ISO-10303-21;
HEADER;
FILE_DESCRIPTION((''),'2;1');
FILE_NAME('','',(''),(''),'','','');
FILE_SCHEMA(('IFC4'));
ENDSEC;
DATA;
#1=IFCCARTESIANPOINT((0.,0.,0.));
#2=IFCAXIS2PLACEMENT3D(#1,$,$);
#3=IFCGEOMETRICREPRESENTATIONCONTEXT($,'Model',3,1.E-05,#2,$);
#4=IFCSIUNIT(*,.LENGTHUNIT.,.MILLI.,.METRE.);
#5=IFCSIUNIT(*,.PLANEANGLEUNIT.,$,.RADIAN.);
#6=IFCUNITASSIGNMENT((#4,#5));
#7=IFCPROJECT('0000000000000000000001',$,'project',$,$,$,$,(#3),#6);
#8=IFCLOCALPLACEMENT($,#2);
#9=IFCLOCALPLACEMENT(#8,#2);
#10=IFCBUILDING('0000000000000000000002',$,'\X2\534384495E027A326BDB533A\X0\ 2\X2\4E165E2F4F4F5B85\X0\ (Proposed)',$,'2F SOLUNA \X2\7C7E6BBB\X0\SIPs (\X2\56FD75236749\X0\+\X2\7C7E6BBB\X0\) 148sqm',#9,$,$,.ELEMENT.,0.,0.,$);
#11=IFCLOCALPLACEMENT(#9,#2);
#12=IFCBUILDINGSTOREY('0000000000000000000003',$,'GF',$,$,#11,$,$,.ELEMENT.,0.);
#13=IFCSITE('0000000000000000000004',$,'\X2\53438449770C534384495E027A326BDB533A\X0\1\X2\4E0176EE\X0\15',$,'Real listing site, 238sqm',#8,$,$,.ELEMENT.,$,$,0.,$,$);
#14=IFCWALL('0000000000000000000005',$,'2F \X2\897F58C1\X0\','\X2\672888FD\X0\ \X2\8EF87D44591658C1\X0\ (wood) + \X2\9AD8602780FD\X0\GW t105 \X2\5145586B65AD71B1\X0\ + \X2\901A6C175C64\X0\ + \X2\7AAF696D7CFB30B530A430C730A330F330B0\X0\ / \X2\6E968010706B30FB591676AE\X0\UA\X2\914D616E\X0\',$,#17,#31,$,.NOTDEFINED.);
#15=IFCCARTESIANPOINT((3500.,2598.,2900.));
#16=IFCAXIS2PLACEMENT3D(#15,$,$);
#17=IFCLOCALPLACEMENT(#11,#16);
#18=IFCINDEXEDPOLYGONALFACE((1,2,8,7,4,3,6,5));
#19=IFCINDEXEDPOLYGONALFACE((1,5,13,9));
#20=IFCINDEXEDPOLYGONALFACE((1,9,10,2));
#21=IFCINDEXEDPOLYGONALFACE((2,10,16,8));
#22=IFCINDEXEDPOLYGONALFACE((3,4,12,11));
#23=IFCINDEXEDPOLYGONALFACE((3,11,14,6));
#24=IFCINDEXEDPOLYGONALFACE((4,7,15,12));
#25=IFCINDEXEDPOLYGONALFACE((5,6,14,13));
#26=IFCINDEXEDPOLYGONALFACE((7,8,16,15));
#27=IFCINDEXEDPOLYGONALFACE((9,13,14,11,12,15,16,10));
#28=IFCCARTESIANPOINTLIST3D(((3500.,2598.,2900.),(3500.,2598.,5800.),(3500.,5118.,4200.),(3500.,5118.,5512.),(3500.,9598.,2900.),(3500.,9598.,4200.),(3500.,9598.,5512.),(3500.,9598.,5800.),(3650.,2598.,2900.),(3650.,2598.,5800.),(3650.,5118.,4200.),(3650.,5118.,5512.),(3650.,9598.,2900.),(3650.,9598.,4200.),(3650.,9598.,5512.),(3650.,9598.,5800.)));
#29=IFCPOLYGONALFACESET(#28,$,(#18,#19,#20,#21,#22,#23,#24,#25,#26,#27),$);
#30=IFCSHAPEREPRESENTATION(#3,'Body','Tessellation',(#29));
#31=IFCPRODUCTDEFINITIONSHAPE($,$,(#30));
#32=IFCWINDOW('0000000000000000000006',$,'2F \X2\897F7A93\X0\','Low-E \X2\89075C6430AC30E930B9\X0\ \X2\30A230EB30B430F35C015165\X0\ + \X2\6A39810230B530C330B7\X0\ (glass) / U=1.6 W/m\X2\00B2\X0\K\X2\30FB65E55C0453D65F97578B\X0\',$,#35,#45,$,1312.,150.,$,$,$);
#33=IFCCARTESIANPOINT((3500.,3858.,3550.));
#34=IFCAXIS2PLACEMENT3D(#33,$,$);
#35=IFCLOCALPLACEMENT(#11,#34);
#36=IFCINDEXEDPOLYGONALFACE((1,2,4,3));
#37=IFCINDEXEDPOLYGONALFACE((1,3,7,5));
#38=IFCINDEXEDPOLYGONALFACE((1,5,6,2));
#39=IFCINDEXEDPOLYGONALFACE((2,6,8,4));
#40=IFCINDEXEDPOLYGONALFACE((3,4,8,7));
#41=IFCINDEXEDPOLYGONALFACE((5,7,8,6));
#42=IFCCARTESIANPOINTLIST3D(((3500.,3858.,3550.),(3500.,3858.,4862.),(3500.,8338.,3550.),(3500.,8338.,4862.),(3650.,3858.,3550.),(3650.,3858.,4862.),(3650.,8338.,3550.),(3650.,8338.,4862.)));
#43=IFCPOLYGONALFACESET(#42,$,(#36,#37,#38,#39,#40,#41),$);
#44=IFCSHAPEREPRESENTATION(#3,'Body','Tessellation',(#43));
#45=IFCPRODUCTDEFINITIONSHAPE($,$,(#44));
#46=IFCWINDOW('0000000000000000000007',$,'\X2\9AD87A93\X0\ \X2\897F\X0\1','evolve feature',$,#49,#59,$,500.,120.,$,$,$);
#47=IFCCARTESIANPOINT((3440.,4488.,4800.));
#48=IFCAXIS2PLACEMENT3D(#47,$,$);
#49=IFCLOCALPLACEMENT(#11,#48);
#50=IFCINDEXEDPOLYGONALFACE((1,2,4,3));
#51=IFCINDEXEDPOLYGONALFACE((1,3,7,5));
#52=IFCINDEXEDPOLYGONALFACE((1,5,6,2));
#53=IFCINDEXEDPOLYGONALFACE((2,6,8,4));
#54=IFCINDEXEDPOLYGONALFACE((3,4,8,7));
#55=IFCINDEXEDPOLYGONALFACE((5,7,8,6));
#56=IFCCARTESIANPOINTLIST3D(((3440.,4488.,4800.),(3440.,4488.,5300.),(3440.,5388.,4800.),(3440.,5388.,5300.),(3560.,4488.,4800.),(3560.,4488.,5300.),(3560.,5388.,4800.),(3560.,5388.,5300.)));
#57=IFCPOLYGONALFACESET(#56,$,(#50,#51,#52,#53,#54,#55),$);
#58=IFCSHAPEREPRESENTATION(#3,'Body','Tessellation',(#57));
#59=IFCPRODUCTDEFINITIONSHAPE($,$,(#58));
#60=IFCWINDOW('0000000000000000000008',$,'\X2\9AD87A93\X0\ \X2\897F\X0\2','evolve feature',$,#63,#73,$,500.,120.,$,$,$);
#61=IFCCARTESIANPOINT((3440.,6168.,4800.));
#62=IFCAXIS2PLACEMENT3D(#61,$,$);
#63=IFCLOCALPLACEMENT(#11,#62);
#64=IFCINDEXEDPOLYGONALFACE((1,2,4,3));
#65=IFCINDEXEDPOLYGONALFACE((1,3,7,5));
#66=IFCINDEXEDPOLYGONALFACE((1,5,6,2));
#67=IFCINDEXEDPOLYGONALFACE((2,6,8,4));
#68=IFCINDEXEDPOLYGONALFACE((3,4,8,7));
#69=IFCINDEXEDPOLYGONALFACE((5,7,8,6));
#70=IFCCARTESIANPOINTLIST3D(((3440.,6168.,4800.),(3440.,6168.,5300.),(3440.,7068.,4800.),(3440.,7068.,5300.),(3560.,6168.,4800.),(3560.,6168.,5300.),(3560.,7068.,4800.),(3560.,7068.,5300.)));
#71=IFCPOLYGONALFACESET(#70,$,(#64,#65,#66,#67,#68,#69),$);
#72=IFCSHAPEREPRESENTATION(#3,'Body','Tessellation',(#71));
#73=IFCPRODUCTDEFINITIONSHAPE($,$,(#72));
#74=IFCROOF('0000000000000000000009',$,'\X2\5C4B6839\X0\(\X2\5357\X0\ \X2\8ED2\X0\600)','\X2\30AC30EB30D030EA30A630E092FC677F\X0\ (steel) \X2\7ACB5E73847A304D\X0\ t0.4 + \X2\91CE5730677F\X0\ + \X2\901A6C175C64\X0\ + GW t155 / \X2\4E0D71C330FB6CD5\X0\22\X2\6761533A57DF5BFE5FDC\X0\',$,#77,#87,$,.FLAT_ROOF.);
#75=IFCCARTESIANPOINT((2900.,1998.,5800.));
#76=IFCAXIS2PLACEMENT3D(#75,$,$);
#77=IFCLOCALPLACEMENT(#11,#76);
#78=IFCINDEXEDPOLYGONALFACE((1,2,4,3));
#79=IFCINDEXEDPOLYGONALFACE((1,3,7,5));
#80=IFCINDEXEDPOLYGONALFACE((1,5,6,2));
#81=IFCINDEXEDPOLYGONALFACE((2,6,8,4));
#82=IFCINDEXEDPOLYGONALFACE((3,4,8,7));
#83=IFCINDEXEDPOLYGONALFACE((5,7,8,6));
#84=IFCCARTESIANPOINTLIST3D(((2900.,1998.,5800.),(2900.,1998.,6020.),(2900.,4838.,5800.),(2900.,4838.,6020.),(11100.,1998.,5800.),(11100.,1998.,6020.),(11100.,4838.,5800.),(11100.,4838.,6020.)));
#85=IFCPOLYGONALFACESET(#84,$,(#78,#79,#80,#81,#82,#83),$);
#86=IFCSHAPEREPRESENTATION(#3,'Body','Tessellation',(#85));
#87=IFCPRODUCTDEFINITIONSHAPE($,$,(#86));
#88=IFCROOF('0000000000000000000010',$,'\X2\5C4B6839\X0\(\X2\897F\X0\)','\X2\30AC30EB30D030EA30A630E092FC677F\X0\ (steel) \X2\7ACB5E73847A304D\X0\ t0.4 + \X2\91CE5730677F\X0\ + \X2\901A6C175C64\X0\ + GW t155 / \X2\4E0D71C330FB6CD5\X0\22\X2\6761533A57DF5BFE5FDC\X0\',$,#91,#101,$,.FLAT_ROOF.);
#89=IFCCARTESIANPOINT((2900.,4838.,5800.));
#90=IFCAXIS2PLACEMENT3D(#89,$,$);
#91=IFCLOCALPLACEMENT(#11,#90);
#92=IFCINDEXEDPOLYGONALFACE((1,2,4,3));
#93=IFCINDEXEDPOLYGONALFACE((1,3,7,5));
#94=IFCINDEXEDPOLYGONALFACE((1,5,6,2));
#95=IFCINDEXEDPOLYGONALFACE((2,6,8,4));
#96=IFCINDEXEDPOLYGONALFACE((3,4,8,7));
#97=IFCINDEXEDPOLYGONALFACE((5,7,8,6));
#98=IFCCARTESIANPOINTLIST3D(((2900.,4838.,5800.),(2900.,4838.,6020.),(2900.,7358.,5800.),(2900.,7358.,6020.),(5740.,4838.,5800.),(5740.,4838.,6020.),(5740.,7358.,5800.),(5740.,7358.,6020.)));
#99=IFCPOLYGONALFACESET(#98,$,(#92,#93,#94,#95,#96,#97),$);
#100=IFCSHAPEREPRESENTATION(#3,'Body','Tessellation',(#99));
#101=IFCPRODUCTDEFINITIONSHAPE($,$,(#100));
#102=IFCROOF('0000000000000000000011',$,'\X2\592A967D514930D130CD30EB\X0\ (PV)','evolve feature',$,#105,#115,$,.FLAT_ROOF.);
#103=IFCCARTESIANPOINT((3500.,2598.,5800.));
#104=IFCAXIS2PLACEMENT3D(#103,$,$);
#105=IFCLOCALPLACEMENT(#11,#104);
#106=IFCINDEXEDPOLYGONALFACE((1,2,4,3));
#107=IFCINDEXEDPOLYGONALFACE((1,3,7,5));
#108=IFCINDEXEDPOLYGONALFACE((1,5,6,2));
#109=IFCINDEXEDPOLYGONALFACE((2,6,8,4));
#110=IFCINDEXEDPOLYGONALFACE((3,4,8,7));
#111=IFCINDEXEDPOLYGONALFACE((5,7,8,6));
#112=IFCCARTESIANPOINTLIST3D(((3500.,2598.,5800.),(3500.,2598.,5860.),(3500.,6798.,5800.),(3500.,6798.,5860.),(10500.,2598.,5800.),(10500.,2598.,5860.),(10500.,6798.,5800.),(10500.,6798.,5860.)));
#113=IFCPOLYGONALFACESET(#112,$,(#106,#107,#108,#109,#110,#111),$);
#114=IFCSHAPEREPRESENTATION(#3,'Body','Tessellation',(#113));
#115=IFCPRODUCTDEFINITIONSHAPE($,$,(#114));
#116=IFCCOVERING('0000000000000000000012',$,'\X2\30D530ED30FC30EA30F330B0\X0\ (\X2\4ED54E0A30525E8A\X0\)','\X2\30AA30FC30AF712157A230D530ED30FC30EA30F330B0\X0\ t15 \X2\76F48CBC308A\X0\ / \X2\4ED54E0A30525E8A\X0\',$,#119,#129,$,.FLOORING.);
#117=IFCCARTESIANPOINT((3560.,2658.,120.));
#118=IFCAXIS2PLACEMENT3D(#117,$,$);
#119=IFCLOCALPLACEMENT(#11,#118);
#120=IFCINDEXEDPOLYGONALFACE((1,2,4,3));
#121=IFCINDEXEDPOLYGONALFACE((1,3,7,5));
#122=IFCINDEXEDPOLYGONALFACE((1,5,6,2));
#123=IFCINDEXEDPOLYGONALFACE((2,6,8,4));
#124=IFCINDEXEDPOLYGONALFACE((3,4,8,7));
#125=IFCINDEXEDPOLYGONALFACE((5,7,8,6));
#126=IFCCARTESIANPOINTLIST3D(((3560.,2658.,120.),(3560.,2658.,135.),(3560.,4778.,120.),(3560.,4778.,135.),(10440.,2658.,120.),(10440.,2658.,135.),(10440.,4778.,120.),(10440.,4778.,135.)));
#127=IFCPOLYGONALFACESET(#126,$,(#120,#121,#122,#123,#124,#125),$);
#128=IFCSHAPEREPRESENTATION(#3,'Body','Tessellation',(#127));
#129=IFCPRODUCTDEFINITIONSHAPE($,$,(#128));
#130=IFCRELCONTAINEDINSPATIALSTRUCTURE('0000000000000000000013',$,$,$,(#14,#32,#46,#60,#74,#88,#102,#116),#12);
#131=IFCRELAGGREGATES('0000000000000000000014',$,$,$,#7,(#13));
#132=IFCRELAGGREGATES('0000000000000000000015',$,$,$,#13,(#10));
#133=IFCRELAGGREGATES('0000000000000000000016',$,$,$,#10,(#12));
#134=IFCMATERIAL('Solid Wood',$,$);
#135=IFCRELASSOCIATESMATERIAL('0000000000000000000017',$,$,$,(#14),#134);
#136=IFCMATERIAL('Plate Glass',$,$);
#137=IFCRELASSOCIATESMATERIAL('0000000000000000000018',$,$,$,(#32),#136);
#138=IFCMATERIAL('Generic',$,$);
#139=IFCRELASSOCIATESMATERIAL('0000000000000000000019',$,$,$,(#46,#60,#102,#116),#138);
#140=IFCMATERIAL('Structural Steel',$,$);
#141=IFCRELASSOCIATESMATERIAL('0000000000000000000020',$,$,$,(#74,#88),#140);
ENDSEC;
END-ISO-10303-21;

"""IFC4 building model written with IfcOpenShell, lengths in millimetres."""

from ifc_helpers import new_model, si_unit, frame, frame_2d, origin, place, context, project, spatial, rectangle, extrude, material, element, fill, save


model = new_model("IFC4")

# Units and contexts
model_context = context("Model", 3, precision=1e-05, world=origin())
ifc_project = project(units=[si_unit("LENGTHUNIT", "METRE", prefix="MILLI"), si_unit("PLANEANGLEUNIT", "RADIAN")], contexts=[model_context])

# Site, building, storey
site_placement = place(None, origin())
site = spatial("IfcSite", under=ifc_project, at=site_placement, Name="千葉県千葉市稲毛区1丁目15", ObjectType="Real listing site, 238sqm", CompositionType="ELEMENT", RefElevation=0.0)
building_placement = place(site_placement, origin())
building = spatial("IfcBuilding", under=site, at=building_placement, Name="千葉市稲毛区 2世帯住宅 (Proposed)", ObjectType="2F SOLUNA 籾殻SIPs (国産杉+籾殻) 148sqm", CompositionType="ELEMENT", ElevationOfRefHeight=0.0, ElevationOfTerrain=0.0)
storey_placement = place(building_placement, origin())
storey = spatial("IfcBuildingStorey", under=building, at=storey_placement, Name="GF", CompositionType="ELEMENT", Elevation=0.0)

# Shared definitions
ifc_material_1 = material(Name="Solid Wood")
ifc_material_2 = material(Name="Generic")

# Shared definitions
ifc_material_3 = material(Name="Plate Glass")

# Wall, openings, windows
wall_1_placement = place(storey_placement, frame((3500.0, 2598.0, 2900.0)))
wall_1 = element("IfcWall", 1, at=wall_1_placement, inside=storey, material=ifc_material_1, Name="2F 西壁", Description="木製 軸組外壁 (wood) + 高性能GW t105 充填断熱 + 通気層 + 窯業系サイディング / 準耐火・外皮UA配慮", PredefinedType="NOTDEFINED", context=model_context, shape_type="SweptSolid", body=[
    extrude(rectangle(XDim=150.0, YDim=7000.0, at=frame_2d((75.0, 3500.0))), frame((3500.0, 2598.0, 2900.0)), (0.0, 0.0, 1.0), 2900.0),
])
opening_1_placement = place(storey_placement, frame((3500.0, 3858.0, 3550.0)))
opening_1 = element("IfcOpeningElement", 2, at=opening_1_placement, cuts=wall_1, PredefinedType="NOTDEFINED", context=model_context, shape_type="SweptSolid", body=[
    extrude(rectangle(XDim=150.0, YDim=4480.0, at=frame_2d((75.0, 2240.0))), frame((3500.0, 3858.0, 3550.0)), (0.0, 0.0, 1.0), 1312.0),
])
opening_2_placement = place(storey_placement, frame((3440.0, 4488.0, 4800.0)))
opening_2 = element("IfcOpeningElement", 3, at=opening_2_placement, cuts=wall_1, PredefinedType="NOTDEFINED", context=model_context, shape_type="SweptSolid", body=[
    extrude(rectangle(XDim=120.0, YDim=900.0, at=frame_2d((60.0, 450.0))), frame((3440.0, 4488.0, 4800.0)), (0.0, 0.0, 1.0), 500.0),
])
opening_3_placement = place(storey_placement, frame((3440.0, 6168.0, 4800.0)))
opening_3 = element("IfcOpeningElement", 4, at=opening_3_placement, cuts=wall_1, PredefinedType="NOTDEFINED", context=model_context, shape_type="SweptSolid", body=[
    extrude(rectangle(XDim=120.0, YDim=900.0, at=frame_2d((60.0, 450.0))), frame((3440.0, 6168.0, 4800.0)), (0.0, 0.0, 1.0), 500.0),
])
window_1_placement = place(storey_placement, frame((3500.0, 3858.0, 3550.0)))
window_1 = element("IfcWindow", 5, at=window_1_placement, inside=storey, material=ifc_material_3, Name="2F 西窓", Description="Low-E 複層ガラス アルゴン封入 + 樹脂サッシ (glass) / U=1.6 W/m²K・日射取得型", OverallHeight=1312.0, OverallWidth=150.0, context=model_context, shape_type="SweptSolid", body=[
    extrude(rectangle(XDim=150.0, YDim=4480.0, at=frame_2d((75.0, 2240.0))), frame((3500.0, 3858.0, 3550.0)), (0.0, 0.0, 1.0), 1312.0),
])
fill(opening_1, window_1)
window_2_placement = place(storey_placement, frame((3440.0, 4488.0, 4800.0)))
window_2 = element("IfcWindow", 6, at=window_2_placement, inside=storey, material=ifc_material_2, Name="高窓 西1", Description="evolve feature", OverallHeight=500.0, OverallWidth=120.0, context=model_context, shape_type="SweptSolid", body=[
    extrude(rectangle(XDim=120.0, YDim=900.0, at=frame_2d((60.0, 450.0))), frame((3440.0, 4488.0, 4800.0)), (0.0, 0.0, 1.0), 500.0),
])
fill(opening_2, window_2)
window_3_placement = place(storey_placement, frame((3440.0, 6168.0, 4800.0)))
window_3 = element("IfcWindow", 7, at=window_3_placement, inside=storey, material=ifc_material_2, Name="高窓 西2", Description="evolve feature", OverallHeight=500.0, OverallWidth=120.0, context=model_context, shape_type="SweptSolid", body=[
    extrude(rectangle(XDim=120.0, YDim=900.0, at=frame_2d((60.0, 450.0))), frame((3440.0, 6168.0, 4800.0)), (0.0, 0.0, 1.0), 500.0),
])
fill(opening_3, window_3)

# Roofs
ifc_material_4 = material(Name="Structural Steel")
roof_1_placement = place(storey_placement, frame((2900.0, 1998.0, 5800.0)))
element("IfcRoof", 8, at=roof_1_placement, inside=storey, material=ifc_material_4, Name="屋根(南 軒600)", Description="ガルバリウム鋼板 (steel) 立平葺き t0.4 + 野地板 + 通気層 + GW t155 / 不燃・法22条区域対応", PredefinedType="FLAT_ROOF", context=model_context, shape_type="SweptSolid", body=[
    extrude(rectangle(XDim=8200.0, YDim=2840.0, at=frame_2d((4100.0, 1420.0))), frame((2900.0, 1998.0, 5800.0)), (0.0, 0.0, 1.0), 220.0),
])
roof_2_placement = place(storey_placement, frame((2900.0, 4838.0, 5800.0)))
element("IfcRoof", 9, at=roof_2_placement, inside=storey, material=ifc_material_4, Name="屋根(西)", Description="ガルバリウム鋼板 (steel) 立平葺き t0.4 + 野地板 + 通気層 + GW t155 / 不燃・法22条区域対応", PredefinedType="FLAT_ROOF", context=model_context, shape_type="SweptSolid", body=[
    extrude(rectangle(XDim=2840.0, YDim=2520.0, at=frame_2d((1420.0, 1260.0))), frame((2900.0, 4838.0, 5800.0)), (0.0, 0.0, 1.0), 220.0),
])
roof_3_placement = place(storey_placement, frame((3500.0, 2598.0, 5800.0)))
element("IfcRoof", 10, at=roof_3_placement, inside=storey, material=ifc_material_2, Name="太陽光パネル (PV)", Description="evolve feature", PredefinedType="FLAT_ROOF", context=model_context, shape_type="SweptSolid", body=[
    extrude(rectangle(XDim=7000.0, YDim=4200.0, at=frame_2d((3500.0, 2100.0))), frame((3500.0, 2598.0, 5800.0)), (0.0, 0.0, 1.0), 60.0),
])

# Covering
covering_placement = place(storey_placement, frame((3560.0, 2658.0, 120.0)))
element("IfcCovering", 11, at=covering_placement, inside=storey, material=ifc_material_2, Name="フローリング (仕上げ床)", Description="オーク無垢フローリング t15 直貼り / 仕上げ床", PredefinedType="FLOORING", context=model_context, shape_type="SweptSolid", body=[
    extrude(rectangle(XDim=6880.0, YDim=2120.0, at=frame_2d((3440.0, 1060.0))), frame((3560.0, 2658.0, 120.0)), (0.0, 0.0, 1.0), 15.0),
])

save(model, "model.ifc")
